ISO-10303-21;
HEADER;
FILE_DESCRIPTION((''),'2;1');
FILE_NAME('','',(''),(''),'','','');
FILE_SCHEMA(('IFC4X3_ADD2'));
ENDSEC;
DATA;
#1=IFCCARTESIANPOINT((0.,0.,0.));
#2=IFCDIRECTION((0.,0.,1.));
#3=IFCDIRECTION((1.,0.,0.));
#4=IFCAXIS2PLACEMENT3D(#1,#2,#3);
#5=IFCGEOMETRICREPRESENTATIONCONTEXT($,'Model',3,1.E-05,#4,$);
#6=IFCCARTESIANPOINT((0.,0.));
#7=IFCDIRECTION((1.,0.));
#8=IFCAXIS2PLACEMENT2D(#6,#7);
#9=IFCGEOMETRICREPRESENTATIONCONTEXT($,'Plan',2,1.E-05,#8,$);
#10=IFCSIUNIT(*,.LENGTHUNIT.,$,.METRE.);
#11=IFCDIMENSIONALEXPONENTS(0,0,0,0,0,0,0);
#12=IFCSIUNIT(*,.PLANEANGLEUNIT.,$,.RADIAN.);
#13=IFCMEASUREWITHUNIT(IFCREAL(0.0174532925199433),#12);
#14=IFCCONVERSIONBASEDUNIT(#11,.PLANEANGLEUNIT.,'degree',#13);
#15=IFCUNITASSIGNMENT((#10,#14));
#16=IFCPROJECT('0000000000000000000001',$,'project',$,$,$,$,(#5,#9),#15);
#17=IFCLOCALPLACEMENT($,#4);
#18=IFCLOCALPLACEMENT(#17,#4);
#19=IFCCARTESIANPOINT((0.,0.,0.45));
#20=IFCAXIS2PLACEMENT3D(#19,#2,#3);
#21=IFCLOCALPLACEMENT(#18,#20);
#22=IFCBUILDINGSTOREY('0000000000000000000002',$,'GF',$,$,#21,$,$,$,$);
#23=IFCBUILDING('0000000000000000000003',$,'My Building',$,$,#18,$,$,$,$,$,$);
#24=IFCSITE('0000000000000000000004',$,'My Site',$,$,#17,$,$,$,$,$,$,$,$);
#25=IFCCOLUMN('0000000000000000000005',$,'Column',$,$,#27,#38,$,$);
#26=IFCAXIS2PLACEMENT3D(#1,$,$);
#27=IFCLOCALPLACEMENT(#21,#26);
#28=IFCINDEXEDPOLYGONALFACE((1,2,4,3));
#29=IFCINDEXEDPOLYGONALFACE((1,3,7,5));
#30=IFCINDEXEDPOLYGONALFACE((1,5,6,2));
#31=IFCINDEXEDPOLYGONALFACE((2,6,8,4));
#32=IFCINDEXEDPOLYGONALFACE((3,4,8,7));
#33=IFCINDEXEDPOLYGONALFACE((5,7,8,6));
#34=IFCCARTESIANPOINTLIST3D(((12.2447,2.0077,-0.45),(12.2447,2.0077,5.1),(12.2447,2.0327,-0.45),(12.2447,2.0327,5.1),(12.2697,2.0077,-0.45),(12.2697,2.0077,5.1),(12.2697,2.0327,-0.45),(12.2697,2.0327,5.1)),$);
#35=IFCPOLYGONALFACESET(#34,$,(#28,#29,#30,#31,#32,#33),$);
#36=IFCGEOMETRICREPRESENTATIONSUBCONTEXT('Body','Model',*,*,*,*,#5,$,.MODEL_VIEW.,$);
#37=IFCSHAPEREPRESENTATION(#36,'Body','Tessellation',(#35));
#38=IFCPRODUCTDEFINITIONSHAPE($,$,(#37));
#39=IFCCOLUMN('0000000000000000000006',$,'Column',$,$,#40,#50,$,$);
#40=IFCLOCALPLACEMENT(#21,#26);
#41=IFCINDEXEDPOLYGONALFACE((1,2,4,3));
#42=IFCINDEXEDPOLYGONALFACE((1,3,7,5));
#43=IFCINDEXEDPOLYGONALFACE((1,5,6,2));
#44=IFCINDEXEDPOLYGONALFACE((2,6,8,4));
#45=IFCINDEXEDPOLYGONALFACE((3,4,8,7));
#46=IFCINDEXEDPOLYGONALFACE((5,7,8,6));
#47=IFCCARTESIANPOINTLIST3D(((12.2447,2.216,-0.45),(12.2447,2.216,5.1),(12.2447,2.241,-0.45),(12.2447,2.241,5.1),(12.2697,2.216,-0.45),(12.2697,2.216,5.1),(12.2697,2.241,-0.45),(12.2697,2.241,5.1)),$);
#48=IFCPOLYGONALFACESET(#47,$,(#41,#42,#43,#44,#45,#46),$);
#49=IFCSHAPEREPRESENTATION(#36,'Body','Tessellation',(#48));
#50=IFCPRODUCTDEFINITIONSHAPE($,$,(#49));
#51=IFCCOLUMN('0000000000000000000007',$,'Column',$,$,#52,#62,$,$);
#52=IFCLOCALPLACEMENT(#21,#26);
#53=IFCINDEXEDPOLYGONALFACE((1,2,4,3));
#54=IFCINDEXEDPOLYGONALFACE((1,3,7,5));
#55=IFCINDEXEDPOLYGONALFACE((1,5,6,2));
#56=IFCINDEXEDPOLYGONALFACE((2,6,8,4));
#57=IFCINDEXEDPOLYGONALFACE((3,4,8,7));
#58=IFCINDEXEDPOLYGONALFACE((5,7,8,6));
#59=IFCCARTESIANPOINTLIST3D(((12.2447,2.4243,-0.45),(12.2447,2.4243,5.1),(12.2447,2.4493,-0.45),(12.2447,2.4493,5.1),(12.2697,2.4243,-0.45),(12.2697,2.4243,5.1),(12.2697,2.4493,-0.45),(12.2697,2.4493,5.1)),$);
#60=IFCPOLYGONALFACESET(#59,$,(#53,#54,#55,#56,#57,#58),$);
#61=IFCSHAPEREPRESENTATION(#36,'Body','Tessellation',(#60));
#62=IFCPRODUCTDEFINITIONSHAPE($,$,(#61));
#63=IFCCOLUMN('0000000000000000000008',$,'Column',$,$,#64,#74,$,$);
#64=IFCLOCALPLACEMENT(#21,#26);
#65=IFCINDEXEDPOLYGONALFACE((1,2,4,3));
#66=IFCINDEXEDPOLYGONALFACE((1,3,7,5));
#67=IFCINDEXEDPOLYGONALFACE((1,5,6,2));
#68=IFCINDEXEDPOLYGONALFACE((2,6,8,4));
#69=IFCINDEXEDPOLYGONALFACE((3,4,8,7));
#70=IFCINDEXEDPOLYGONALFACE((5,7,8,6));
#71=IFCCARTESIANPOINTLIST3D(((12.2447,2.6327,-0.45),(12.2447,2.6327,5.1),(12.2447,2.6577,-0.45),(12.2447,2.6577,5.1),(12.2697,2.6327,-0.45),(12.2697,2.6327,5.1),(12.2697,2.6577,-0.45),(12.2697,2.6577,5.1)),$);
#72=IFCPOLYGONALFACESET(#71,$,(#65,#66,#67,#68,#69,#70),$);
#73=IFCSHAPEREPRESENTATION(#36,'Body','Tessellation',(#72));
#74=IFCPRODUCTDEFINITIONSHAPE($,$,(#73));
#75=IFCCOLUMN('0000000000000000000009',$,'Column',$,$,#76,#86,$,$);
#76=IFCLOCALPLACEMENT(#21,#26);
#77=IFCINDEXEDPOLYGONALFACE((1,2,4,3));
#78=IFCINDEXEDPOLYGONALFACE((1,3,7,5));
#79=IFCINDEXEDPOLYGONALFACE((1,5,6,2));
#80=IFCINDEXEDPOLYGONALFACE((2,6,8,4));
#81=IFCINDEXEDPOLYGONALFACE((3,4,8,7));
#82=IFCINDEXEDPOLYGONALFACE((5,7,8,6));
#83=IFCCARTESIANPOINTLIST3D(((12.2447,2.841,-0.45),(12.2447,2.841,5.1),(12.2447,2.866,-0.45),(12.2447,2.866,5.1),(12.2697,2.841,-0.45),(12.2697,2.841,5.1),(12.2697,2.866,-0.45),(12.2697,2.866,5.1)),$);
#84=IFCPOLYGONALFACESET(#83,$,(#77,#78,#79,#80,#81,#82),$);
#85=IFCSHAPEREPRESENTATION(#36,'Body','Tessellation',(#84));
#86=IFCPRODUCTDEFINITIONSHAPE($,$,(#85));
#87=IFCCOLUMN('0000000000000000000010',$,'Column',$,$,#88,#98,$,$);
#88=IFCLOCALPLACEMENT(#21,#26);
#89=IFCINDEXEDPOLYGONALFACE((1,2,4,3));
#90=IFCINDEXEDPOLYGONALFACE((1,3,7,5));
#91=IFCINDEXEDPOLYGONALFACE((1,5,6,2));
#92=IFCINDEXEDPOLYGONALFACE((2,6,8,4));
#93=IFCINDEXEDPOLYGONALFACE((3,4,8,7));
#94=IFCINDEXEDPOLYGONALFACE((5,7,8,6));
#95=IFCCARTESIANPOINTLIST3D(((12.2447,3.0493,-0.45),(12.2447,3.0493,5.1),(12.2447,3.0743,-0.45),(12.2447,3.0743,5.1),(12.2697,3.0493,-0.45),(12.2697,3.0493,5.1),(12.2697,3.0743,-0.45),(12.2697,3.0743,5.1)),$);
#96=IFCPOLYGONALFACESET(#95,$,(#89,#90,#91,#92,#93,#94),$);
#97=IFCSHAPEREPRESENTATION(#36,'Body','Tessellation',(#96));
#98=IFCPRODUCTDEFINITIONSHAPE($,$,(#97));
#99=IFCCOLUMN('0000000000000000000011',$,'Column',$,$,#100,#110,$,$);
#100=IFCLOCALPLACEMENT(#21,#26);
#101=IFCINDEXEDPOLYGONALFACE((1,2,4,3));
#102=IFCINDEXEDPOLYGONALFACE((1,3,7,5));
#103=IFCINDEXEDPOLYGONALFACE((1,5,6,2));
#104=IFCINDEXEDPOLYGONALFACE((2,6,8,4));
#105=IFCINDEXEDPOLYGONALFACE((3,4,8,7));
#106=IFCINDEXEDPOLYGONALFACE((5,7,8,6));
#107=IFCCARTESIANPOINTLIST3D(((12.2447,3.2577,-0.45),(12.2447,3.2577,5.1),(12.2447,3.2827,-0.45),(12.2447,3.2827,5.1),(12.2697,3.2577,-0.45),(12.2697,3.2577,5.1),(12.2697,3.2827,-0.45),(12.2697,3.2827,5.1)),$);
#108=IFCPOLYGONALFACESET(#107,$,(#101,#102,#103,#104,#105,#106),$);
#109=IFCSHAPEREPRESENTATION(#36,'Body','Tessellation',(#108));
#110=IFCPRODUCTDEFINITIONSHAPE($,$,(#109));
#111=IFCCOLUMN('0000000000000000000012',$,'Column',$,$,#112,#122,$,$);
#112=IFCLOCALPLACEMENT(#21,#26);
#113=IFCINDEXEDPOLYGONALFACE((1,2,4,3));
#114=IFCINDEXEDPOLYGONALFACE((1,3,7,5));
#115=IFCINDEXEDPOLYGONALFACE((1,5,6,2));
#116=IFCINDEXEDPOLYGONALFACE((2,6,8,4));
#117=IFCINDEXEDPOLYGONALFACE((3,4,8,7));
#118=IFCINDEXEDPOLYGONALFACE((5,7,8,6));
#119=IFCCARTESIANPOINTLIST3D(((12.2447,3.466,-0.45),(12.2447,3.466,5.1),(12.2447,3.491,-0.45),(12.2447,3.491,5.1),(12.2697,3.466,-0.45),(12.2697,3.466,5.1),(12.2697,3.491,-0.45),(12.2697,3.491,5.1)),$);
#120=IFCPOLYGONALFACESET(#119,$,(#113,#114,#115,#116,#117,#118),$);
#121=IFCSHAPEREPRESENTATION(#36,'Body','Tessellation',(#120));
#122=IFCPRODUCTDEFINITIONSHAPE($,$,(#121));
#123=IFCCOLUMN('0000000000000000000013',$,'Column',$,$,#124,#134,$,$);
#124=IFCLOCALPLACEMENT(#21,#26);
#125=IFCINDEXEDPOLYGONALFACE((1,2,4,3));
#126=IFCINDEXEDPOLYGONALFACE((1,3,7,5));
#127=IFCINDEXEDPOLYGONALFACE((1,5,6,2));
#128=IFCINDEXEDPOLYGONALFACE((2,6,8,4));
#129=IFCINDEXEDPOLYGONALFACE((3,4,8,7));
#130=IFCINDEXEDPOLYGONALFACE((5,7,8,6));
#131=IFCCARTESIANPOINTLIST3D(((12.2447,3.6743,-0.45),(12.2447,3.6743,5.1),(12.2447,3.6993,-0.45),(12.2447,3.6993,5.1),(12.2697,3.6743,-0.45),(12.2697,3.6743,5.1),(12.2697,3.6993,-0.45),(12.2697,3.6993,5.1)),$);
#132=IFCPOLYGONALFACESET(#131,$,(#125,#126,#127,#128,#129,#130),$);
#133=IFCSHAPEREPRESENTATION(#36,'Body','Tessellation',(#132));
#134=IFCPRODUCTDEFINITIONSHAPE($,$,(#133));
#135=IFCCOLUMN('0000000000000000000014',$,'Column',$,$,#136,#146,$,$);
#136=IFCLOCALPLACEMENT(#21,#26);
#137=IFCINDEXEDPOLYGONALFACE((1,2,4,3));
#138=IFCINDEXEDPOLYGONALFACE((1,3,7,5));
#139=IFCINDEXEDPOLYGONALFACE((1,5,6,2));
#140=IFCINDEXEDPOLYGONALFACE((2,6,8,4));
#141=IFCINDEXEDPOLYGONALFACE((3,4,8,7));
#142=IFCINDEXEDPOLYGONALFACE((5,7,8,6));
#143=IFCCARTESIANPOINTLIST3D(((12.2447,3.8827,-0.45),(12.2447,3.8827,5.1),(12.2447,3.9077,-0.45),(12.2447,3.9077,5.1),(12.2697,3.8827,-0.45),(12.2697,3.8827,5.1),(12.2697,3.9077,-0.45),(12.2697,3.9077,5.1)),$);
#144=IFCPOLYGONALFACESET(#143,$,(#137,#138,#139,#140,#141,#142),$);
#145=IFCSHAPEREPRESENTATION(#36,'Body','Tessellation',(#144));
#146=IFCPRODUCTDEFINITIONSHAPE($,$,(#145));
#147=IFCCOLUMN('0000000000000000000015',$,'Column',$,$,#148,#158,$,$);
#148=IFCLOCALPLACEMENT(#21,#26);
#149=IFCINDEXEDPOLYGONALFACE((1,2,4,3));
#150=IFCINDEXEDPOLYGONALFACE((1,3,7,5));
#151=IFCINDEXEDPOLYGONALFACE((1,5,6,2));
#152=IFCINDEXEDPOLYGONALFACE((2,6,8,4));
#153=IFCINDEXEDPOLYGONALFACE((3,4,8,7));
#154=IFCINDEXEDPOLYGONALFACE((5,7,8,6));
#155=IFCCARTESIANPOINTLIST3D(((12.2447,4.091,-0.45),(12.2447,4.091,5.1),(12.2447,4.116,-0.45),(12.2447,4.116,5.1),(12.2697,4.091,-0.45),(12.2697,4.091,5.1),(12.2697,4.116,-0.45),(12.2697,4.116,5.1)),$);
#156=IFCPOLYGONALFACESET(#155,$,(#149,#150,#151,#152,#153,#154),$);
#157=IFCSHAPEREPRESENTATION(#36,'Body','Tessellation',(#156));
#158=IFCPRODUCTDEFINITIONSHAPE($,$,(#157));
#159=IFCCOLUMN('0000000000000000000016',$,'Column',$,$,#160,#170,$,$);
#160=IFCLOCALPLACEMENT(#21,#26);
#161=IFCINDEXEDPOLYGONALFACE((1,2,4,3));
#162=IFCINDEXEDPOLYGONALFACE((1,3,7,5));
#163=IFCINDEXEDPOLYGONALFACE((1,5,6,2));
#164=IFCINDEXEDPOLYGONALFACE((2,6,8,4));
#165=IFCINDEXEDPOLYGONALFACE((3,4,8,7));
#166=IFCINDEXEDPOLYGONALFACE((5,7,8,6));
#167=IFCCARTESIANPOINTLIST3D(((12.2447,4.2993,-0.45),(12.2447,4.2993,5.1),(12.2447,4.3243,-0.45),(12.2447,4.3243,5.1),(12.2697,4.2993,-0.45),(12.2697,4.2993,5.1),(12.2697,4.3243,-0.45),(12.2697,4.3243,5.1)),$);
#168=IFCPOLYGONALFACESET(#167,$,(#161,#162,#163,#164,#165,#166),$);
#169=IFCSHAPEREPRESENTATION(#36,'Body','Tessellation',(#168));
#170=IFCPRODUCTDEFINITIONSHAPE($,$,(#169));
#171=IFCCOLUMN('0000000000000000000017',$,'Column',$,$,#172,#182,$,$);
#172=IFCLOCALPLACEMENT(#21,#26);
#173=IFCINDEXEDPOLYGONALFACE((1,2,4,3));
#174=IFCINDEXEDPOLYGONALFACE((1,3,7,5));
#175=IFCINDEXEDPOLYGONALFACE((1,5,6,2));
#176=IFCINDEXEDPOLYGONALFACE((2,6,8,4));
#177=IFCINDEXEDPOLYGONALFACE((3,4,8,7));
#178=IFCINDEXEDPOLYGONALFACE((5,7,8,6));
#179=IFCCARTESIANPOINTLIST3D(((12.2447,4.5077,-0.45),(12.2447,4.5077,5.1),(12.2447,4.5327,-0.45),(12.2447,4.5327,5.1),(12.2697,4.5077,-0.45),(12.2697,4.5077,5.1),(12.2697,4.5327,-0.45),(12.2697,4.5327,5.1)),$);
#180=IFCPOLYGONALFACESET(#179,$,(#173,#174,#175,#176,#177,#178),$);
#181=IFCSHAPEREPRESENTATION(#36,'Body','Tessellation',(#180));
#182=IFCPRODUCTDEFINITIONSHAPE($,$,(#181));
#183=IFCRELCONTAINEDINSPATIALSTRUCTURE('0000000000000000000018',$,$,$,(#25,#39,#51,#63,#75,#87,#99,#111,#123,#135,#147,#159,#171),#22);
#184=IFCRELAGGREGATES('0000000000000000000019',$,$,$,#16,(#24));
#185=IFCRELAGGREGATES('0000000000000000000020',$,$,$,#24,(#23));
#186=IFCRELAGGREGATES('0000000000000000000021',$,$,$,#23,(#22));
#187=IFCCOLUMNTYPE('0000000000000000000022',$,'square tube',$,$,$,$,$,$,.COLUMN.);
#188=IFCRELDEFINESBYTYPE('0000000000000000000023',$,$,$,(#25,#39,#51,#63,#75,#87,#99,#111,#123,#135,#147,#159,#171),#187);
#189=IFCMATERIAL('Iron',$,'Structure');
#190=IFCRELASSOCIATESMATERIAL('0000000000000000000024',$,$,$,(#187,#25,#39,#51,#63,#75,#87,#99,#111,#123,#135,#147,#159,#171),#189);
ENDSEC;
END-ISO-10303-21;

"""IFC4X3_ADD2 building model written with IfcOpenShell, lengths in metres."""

from ifc_helpers import new_model, entity, si_unit, converted_unit, frame, origin_with_axes, origin_2d_with_axis, place, context, subcontext, project, spatial, indexed_curve, outline, extrude, material, material_profile, profile_set, profile_usage, type_object, element, save


model = new_model("IFC4X3_ADD2")

# Units and contexts
model_context = context("Model", 3, precision=1e-05, world=origin_with_axes())
plan_context = context("Plan", 2, precision=1e-05, world=origin_2d_with_axis())
body_context = subcontext(model_context, "Body", "Model", "MODEL_VIEW")
ifc_project = project(units=[si_unit("LENGTHUNIT", "METRE"), converted_unit("PLANEANGLEUNIT", "degree", entity("IfcReal", 0.0174532925199433), si_unit("PLANEANGLEUNIT", "RADIAN"), dimensions=[0, 0, 0, 0, 0, 0, 0])], contexts=[model_context, plan_context])

# Site, building, storey
site_placement = place(None, origin_with_axes())
site = spatial("IfcSite", under=ifc_project, at=site_placement, Name="My Site")
building_placement = place(site_placement, origin_with_axes())
building = spatial("IfcBuilding", under=site, at=building_placement, Name="My Building")
storey_placement = place(building_placement, frame((0.0, 0.0, 0.45), z_axis=(0.0, 0.0, 1.0), x_axis=(1.0, 0.0, 0.0)))
storey = spatial("IfcBuildingStorey", under=building, at=storey_placement, Name="GF")

# Columns
ifc_material_1 = material(Name="Iron", Category="Structure")
ifc_material_profile = material_profile(ifc_material_1, outline(indexed_curve([(-0.0125, -0.0125), (0.0125, -0.0125), (0.0125, 0.0125), (-0.0125, 0.0125), (-0.0125, -0.0125)])))
ifc_profile_set = profile_set([ifc_material_profile])
ifc_profile_usage_1 = profile_usage(ifc_profile_set, cardinal=5)
column_type = type_object("IfcColumnType", Name="square tube", PredefinedType="COLUMN", material=ifc_profile_set)
column_1_placement = place(storey_placement, frame((12.2572, 2.0202, -0.45), z_axis=(0.0, 0.0, 1.0), x_axis=(0.0, 1.0, 0.0)))
element("IfcColumn", 1, at=column_1_placement, inside=storey, type_object=column_type, material=ifc_profile_usage_1, Name="Column", context=body_context, shape_type="SweptSolid", body=[
    extrude(outline(indexed_curve([(-0.0125, -0.0125), (0.0125, -0.0125), (0.0125, 0.0125), (-0.0125, 0.0125), (-0.0125, -0.0125)])), origin_with_axes(), (0.0, 0.0, 1.0), 5.55),
])
ifc_profile_usage_2 = profile_usage(ifc_profile_set, cardinal=5)
column_2_placement = place(storey_placement, frame((12.2572, 2.2285, -0.45), z_axis=(0.0, 0.0, 1.0), x_axis=(0.0, 1.0, 0.0)))
element("IfcColumn", 2, at=column_2_placement, inside=storey, type_object=column_type, material=ifc_profile_usage_2, Name="Column", context=body_context, shape_type="SweptSolid", body=[
    extrude(outline(indexed_curve([(-0.0125, -0.0125), (0.0125, -0.0125), (0.0125, 0.0125), (-0.0125, 0.0125), (-0.0125, -0.0125)])), origin_with_axes(), (0.0, 0.0, 1.0), 5.55),
])
ifc_profile_usage_3 = profile_usage(ifc_profile_set, cardinal=5)
column_3_placement = place(storey_placement, frame((12.2572, 2.4368, -0.45), z_axis=(0.0, 0.0, 1.0), x_axis=(0.0, 1.0, 0.0)))
element("IfcColumn", 3, at=column_3_placement, inside=storey, type_object=column_type, material=ifc_profile_usage_3, Name="Column", context=body_context, shape_type="SweptSolid", body=[
    extrude(outline(indexed_curve([(-0.0125, -0.0125), (0.0125, -0.0125), (0.0125, 0.0125), (-0.0125, 0.0125), (-0.0125, -0.0125)])), origin_with_axes(), (0.0, 0.0, 1.0), 5.55),
])
ifc_profile_usage_4 = profile_usage(ifc_profile_set, cardinal=5)
column_4_placement = place(storey_placement, frame((12.2572, 2.6452, -0.45), z_axis=(0.0, 0.0, 1.0), x_axis=(0.0, 1.0, 0.0)))
element("IfcColumn", 4, at=column_4_placement, inside=storey, type_object=column_type, material=ifc_profile_usage_4, Name="Column", context=body_context, shape_type="SweptSolid", body=[
    extrude(outline(indexed_curve([(-0.0125, -0.0125), (0.0125, -0.0125), (0.0125, 0.0125), (-0.0125, 0.0125), (-0.0125, -0.0125)])), origin_with_axes(), (0.0, 0.0, 1.0), 5.55),
])
ifc_profile_usage_5 = profile_usage(ifc_profile_set, cardinal=5)
column_5_placement = place(storey_placement, frame((12.2572, 2.8535, -0.45), z_axis=(0.0, 0.0, 1.0), x_axis=(0.0, 1.0, 0.0)))
element("IfcColumn", 5, at=column_5_placement, inside=storey, type_object=column_type, material=ifc_profile_usage_5, Name="Column", context=body_context, shape_type="SweptSolid", body=[
    extrude(outline(indexed_curve([(-0.0125, -0.0125), (0.0125, -0.0125), (0.0125, 0.0125), (-0.0125, 0.0125), (-0.0125, -0.0125)])), origin_with_axes(), (0.0, 0.0, 1.0), 5.55),
])
ifc_profile_usage_6 = profile_usage(ifc_profile_set, cardinal=5)
column_6_placement = place(storey_placement, frame((12.2572, 3.0618, -0.45), z_axis=(0.0, 0.0, 1.0), x_axis=(0.0, 1.0, 0.0)))
element("IfcColumn", 6, at=column_6_placement, inside=storey, type_object=column_type, material=ifc_profile_usage_6, Name="Column", context=body_context, shape_type="SweptSolid", body=[
    extrude(outline(indexed_curve([(-0.0125, -0.0125), (0.0125, -0.0125), (0.0125, 0.0125), (-0.0125, 0.0125), (-0.0125, -0.0125)])), origin_with_axes(), (0.0, 0.0, 1.0), 5.55),
])
ifc_profile_usage_7 = profile_usage(ifc_profile_set, cardinal=5)
column_7_placement = place(storey_placement, frame((12.2572, 3.2702, -0.45), z_axis=(0.0, 0.0, 1.0), x_axis=(0.0, 1.0, 0.0)))
element("IfcColumn", 7, at=column_7_placement, inside=storey, type_object=column_type, material=ifc_profile_usage_7, Name="Column", context=body_context, shape_type="SweptSolid", body=[
    extrude(outline(indexed_curve([(-0.0125, -0.0125), (0.0125, -0.0125), (0.0125, 0.0125), (-0.0125, 0.0125), (-0.0125, -0.0125)])), origin_with_axes(), (0.0, 0.0, 1.0), 5.55),
])
ifc_profile_usage_8 = profile_usage(ifc_profile_set, cardinal=5)
column_8_placement = place(storey_placement, frame((12.2572, 3.4785, -0.45), z_axis=(0.0, 0.0, 1.0), x_axis=(0.0, 1.0, 0.0)))
element("IfcColumn", 8, at=column_8_placement, inside=storey, type_object=column_type, material=ifc_profile_usage_8, Name="Column", context=body_context, shape_type="SweptSolid", body=[
    extrude(outline(indexed_curve([(-0.0125, -0.0125), (0.0125, -0.0125), (0.0125, 0.0125), (-0.0125, 0.0125), (-0.0125, -0.0125)])), origin_with_axes(), (0.0, 0.0, 1.0), 5.55),
])
ifc_profile_usage_9 = profile_usage(ifc_profile_set, cardinal=5)
column_9_placement = place(storey_placement, frame((12.2572, 3.6868, -0.45), z_axis=(0.0, 0.0, 1.0), x_axis=(0.0, 1.0, 0.0)))
element("IfcColumn", 9, at=column_9_placement, inside=storey, type_object=column_type, material=ifc_profile_usage_9, Name="Column", context=body_context, shape_type="SweptSolid", body=[
    extrude(outline(indexed_curve([(-0.0125, -0.0125), (0.0125, -0.0125), (0.0125, 0.0125), (-0.0125, 0.0125), (-0.0125, -0.0125)])), origin_with_axes(), (0.0, 0.0, 1.0), 5.55),
])
ifc_profile_usage_10 = profile_usage(ifc_profile_set, cardinal=5)
column_10_placement = place(storey_placement, frame((12.2572, 3.8952, -0.45), z_axis=(0.0, 0.0, 1.0), x_axis=(0.0, 1.0, 0.0)))
element("IfcColumn", 10, at=column_10_placement, inside=storey, type_object=column_type, material=ifc_profile_usage_10, Name="Column", context=body_context, shape_type="SweptSolid", body=[
    extrude(outline(indexed_curve([(-0.0125, -0.0125), (0.0125, -0.0125), (0.0125, 0.0125), (-0.0125, 0.0125), (-0.0125, -0.0125)])), origin_with_axes(), (0.0, 0.0, 1.0), 5.55),
])
ifc_profile_usage_11 = profile_usage(ifc_profile_set, cardinal=5)
column_11_placement = place(storey_placement, frame((12.2572, 4.1035, -0.45), z_axis=(0.0, 0.0, 1.0), x_axis=(0.0, 1.0, 0.0)))
element("IfcColumn", 11, at=column_11_placement, inside=storey, type_object=column_type, material=ifc_profile_usage_11, Name="Column", context=body_context, shape_type="SweptSolid", body=[
    extrude(outline(indexed_curve([(-0.0125, -0.0125), (0.0125, -0.0125), (0.0125, 0.0125), (-0.0125, 0.0125), (-0.0125, -0.0125)])), origin_with_axes(), (0.0, 0.0, 1.0), 5.55),
])
ifc_profile_usage_12 = profile_usage(ifc_profile_set, cardinal=5)
column_12_placement = place(storey_placement, frame((12.2572, 4.3118, -0.45), z_axis=(0.0, 0.0, 1.0), x_axis=(0.0, 1.0, 0.0)))
element("IfcColumn", 12, at=column_12_placement, inside=storey, type_object=column_type, material=ifc_profile_usage_12, Name="Column", context=body_context, shape_type="SweptSolid", body=[
    extrude(outline(indexed_curve([(-0.0125, -0.0125), (0.0125, -0.0125), (0.0125, 0.0125), (-0.0125, 0.0125), (-0.0125, -0.0125)])), origin_with_axes(), (0.0, 0.0, 1.0), 5.55),
])
ifc_profile_usage_13 = profile_usage(ifc_profile_set, cardinal=5)
column_13_placement = place(storey_placement, frame((12.2572, 4.5202, -0.45), z_axis=(0.0, 0.0, 1.0), x_axis=(0.0, 1.0, 0.0)))
element("IfcColumn", 13, at=column_13_placement, inside=storey, type_object=column_type, material=ifc_profile_usage_13, Name="Column", context=body_context, shape_type="SweptSolid", body=[
    extrude(outline(indexed_curve([(-0.0125, -0.0125), (0.0125, -0.0125), (0.0125, 0.0125), (-0.0125, 0.0125), (-0.0125, -0.0125)])), origin_with_axes(), (0.0, 0.0, 1.0), 5.55),
])

save(model, "model.ifc")
